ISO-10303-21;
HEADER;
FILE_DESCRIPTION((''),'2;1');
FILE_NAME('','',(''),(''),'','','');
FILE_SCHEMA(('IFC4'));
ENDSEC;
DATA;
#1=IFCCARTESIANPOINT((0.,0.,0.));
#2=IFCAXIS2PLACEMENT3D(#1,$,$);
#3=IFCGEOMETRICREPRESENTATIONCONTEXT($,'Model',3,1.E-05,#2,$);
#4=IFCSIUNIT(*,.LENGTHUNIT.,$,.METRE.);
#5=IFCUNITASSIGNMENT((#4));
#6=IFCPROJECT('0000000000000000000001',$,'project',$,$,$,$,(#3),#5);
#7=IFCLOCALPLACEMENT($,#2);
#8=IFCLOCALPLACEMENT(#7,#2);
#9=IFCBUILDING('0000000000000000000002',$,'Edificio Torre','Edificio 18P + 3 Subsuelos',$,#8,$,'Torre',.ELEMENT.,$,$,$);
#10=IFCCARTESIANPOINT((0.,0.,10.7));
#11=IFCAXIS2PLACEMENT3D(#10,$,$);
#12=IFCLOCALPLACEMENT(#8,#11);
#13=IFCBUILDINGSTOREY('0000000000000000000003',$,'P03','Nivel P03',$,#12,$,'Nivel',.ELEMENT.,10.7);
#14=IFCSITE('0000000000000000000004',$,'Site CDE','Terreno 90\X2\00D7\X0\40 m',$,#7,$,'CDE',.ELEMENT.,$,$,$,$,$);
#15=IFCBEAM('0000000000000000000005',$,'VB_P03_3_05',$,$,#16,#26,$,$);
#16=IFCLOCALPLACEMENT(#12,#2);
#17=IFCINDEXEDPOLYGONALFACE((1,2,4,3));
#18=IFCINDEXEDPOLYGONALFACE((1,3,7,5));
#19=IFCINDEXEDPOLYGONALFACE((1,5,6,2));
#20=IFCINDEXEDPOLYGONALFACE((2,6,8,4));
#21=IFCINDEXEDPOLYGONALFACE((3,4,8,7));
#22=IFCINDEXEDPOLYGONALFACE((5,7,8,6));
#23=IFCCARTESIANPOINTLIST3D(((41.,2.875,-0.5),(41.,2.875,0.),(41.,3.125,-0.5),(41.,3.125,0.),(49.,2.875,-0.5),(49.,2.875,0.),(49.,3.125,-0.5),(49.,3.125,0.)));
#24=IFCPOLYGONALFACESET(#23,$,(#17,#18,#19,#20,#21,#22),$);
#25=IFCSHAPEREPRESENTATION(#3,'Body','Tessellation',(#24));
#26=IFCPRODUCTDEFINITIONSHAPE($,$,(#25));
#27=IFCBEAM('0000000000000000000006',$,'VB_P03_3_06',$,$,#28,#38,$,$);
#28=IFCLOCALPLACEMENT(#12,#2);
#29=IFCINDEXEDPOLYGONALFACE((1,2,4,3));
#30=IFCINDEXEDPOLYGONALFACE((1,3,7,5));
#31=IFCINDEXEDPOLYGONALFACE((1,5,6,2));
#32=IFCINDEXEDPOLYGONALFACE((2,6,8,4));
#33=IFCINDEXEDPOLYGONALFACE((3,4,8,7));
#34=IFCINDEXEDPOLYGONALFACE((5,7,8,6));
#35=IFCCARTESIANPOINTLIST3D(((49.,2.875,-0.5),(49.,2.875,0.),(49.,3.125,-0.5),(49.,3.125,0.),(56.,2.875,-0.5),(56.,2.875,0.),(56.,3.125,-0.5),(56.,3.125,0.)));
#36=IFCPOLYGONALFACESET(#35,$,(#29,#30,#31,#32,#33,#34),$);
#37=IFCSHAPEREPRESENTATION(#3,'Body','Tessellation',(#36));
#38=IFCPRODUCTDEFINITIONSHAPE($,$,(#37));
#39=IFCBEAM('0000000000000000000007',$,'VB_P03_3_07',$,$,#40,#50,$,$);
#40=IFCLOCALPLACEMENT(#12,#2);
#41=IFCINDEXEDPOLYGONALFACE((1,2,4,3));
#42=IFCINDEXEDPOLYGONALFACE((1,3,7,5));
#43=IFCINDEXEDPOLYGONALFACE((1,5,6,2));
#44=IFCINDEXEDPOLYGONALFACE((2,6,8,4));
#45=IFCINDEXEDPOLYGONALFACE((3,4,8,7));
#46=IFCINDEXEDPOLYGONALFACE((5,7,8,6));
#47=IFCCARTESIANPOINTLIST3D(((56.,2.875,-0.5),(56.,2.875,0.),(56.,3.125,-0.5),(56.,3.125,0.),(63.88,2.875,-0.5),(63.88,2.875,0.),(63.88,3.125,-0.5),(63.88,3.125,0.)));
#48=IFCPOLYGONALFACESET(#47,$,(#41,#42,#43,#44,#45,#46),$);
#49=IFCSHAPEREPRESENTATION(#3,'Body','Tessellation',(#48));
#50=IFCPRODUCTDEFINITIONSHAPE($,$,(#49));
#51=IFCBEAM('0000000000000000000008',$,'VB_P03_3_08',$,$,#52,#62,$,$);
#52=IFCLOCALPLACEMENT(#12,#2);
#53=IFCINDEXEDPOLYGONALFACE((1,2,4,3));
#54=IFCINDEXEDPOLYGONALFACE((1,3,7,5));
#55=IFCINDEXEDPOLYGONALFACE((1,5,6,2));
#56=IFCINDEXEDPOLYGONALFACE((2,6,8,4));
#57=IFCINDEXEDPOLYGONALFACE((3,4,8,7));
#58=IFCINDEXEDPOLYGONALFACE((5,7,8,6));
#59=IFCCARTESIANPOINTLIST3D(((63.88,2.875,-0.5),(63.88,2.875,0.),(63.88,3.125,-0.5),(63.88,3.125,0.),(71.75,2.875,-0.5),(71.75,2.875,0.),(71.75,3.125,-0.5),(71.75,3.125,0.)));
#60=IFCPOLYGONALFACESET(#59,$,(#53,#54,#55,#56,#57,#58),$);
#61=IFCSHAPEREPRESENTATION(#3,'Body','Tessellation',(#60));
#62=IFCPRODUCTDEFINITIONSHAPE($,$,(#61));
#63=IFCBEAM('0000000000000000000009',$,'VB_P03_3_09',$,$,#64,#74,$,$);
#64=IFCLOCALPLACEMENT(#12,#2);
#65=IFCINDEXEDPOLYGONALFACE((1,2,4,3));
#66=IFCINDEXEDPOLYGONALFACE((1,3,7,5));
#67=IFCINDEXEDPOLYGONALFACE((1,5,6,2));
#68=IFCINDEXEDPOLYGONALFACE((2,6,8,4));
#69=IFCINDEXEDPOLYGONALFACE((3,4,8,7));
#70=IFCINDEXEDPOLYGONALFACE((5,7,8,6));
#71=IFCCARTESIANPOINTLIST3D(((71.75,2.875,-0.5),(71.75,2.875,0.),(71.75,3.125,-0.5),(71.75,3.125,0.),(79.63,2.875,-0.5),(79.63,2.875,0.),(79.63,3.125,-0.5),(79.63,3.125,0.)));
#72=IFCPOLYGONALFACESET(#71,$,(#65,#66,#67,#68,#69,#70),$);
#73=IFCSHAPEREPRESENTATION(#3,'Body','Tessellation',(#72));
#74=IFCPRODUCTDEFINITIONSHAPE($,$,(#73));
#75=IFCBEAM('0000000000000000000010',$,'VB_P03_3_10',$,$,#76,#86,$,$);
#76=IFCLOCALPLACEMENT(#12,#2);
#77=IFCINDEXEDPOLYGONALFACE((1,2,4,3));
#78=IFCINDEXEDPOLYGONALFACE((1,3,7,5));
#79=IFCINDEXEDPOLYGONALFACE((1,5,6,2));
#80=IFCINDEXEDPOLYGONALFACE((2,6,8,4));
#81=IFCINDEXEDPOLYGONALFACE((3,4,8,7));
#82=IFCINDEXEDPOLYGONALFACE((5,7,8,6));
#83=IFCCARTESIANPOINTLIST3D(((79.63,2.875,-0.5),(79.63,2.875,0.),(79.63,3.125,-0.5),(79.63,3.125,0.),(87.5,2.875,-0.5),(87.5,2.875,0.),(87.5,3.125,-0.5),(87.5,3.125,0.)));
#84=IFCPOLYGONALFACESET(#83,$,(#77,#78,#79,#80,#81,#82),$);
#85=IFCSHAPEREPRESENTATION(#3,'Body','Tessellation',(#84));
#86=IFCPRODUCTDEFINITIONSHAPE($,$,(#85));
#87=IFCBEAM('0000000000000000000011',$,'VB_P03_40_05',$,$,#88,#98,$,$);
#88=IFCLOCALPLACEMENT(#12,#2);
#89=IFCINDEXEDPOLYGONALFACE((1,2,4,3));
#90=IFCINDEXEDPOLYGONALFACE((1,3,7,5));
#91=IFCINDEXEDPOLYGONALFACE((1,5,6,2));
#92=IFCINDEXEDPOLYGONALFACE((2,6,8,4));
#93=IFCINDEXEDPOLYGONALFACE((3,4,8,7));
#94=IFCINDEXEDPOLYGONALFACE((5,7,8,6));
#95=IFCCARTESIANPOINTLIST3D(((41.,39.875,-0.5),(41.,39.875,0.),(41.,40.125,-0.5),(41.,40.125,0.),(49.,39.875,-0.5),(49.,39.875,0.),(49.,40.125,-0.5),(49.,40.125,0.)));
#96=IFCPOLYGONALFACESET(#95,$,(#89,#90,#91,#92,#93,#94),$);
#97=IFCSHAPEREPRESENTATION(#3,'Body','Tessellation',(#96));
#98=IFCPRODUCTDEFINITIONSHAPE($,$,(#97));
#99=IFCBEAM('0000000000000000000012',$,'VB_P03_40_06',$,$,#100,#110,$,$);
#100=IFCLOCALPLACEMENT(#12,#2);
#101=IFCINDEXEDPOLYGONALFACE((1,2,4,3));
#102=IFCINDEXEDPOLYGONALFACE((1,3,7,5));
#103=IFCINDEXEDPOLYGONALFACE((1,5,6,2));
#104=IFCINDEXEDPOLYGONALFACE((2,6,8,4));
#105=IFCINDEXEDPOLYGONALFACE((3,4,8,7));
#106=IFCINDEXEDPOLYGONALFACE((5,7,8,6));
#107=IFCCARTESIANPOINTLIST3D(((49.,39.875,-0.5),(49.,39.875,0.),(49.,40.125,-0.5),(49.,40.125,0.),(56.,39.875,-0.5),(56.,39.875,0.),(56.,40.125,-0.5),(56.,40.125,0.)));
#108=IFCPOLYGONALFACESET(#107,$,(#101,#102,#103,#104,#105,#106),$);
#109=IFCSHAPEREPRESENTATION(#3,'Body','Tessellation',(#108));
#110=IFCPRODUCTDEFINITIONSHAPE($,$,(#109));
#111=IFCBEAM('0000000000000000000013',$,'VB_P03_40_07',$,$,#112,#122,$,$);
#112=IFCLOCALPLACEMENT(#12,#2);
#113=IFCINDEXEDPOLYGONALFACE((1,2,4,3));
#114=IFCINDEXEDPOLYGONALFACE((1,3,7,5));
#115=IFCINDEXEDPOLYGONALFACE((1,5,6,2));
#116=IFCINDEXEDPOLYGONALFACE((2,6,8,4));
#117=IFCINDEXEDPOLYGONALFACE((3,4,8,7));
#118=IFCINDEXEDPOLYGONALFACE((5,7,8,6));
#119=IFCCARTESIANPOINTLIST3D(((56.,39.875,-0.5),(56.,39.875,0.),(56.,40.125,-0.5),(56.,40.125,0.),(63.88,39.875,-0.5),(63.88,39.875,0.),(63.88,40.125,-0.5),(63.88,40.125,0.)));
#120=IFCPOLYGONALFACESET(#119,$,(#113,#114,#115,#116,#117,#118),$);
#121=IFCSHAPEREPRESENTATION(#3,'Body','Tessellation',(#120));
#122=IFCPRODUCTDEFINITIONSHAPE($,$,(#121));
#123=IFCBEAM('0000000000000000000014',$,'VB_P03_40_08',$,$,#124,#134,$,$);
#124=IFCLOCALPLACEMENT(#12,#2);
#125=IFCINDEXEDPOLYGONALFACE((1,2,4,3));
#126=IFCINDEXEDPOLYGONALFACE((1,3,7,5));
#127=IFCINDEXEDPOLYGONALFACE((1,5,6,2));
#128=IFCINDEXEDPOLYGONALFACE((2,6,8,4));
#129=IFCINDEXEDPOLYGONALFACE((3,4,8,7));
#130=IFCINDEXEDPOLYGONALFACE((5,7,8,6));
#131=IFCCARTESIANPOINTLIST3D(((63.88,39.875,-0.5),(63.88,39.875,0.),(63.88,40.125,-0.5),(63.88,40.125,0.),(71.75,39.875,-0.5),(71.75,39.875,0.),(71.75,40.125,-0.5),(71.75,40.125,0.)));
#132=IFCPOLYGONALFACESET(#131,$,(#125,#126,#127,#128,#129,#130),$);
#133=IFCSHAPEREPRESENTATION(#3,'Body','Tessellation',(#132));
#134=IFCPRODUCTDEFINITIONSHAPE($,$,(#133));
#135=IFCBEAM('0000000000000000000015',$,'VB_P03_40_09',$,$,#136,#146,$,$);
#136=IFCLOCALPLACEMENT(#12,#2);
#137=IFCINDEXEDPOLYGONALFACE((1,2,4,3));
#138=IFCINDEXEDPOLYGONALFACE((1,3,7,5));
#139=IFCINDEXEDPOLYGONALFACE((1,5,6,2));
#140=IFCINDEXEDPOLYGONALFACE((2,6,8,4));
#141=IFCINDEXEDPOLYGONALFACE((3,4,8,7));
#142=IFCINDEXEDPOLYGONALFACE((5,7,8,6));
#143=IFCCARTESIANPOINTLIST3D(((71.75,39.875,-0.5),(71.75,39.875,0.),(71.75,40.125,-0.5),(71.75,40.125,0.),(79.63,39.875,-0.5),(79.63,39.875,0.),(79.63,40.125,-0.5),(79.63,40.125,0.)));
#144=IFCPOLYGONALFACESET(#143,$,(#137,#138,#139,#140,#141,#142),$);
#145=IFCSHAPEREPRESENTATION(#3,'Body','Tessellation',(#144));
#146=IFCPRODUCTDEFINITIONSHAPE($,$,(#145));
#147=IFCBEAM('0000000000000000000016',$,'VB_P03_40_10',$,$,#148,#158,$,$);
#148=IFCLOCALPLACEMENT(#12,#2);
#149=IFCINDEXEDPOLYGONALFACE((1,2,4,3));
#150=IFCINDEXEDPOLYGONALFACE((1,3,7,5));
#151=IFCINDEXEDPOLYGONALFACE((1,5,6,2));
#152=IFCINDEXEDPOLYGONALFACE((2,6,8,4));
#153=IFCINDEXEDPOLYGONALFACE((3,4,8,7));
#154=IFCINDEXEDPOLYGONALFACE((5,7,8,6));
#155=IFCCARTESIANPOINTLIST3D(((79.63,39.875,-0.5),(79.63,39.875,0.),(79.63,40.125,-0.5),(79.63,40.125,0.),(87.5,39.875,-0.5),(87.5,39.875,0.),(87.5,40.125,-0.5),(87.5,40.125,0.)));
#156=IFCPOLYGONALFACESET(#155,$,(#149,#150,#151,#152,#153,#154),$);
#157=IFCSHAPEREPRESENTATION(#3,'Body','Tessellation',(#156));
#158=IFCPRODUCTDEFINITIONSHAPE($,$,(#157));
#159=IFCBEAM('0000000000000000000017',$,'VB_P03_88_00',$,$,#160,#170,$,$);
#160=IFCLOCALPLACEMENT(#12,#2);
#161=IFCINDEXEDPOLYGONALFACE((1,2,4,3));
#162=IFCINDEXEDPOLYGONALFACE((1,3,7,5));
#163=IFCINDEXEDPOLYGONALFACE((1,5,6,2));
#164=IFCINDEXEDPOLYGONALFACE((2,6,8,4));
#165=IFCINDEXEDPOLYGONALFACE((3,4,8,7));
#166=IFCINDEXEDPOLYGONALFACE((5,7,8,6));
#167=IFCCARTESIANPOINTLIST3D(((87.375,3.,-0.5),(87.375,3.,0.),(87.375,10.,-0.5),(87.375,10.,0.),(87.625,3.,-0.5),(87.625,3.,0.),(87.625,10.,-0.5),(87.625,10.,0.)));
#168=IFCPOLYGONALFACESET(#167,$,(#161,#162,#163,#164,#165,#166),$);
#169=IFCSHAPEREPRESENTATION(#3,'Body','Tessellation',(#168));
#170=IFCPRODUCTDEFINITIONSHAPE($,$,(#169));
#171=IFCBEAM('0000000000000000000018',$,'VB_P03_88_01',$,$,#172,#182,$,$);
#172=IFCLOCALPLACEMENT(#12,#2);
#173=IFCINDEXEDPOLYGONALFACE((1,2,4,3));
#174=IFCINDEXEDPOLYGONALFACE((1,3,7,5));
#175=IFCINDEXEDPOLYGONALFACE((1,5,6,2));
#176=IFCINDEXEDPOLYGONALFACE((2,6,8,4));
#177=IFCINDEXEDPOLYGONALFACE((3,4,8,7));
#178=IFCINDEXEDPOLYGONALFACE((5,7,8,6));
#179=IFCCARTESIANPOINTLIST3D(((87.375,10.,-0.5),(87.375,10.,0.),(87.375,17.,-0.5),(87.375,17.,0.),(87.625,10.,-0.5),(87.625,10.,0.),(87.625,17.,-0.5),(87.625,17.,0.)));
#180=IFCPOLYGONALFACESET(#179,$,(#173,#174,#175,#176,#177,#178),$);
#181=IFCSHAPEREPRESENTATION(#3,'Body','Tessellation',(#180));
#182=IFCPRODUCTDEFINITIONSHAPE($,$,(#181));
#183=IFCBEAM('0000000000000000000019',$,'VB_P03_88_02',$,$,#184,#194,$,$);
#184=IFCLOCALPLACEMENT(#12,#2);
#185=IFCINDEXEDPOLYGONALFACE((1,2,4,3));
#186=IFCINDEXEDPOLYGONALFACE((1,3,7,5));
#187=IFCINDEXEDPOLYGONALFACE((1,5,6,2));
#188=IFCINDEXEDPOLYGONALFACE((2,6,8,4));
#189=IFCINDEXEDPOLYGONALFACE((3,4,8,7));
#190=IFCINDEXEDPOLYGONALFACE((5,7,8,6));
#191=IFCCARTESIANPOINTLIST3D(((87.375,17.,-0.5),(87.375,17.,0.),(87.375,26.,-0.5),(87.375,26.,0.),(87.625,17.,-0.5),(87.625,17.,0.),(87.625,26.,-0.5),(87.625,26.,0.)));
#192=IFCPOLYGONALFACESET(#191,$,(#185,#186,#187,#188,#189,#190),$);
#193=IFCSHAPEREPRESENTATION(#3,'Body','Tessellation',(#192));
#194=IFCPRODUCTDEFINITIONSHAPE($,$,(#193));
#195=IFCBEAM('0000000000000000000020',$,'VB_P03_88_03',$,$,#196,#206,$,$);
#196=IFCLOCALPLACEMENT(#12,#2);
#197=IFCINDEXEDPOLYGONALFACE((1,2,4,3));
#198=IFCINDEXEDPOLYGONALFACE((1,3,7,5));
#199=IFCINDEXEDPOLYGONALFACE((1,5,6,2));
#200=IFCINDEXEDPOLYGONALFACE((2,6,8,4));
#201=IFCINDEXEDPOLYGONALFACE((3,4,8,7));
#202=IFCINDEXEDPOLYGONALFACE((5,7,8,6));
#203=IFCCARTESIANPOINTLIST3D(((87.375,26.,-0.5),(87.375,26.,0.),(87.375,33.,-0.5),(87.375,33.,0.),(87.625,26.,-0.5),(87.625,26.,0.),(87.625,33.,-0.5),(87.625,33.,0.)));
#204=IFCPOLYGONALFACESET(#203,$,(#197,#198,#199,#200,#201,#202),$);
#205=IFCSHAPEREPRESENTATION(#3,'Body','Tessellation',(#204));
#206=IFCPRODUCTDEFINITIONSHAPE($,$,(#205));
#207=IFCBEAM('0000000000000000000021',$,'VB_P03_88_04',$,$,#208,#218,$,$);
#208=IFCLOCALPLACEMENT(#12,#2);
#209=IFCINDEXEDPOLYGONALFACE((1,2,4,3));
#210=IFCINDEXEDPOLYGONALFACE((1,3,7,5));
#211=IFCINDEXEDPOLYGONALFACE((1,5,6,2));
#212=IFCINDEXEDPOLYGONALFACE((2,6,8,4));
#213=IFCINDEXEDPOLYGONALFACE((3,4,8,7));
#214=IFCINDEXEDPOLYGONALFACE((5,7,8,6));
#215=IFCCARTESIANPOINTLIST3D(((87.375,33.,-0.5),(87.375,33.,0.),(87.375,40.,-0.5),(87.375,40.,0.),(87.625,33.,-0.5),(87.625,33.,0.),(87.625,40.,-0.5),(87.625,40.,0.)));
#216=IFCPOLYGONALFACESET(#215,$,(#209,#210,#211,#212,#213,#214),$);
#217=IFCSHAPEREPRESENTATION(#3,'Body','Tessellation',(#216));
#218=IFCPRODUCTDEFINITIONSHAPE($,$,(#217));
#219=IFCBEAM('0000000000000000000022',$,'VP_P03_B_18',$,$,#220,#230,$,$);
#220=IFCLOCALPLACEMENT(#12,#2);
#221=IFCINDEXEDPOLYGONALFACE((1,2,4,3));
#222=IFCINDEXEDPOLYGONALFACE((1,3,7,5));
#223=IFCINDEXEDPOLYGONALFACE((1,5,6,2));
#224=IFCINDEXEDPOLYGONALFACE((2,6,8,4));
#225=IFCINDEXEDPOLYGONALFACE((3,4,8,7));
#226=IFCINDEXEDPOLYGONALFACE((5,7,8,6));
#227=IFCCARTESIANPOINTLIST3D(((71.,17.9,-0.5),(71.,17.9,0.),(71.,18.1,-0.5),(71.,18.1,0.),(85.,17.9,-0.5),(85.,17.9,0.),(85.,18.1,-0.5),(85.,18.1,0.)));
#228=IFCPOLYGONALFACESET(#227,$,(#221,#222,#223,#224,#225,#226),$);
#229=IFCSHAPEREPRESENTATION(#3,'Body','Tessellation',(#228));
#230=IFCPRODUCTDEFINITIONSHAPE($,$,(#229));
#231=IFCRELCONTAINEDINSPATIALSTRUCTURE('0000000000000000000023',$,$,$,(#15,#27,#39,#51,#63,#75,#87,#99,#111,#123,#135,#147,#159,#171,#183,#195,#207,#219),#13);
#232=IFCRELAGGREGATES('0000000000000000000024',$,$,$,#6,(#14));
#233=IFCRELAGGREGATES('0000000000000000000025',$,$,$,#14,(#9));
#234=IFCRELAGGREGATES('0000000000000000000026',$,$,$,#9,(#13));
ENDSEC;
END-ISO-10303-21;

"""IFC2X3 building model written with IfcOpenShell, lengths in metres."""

from ifc_helpers import new_model, si_unit, frame, origin, origin_2d, place, context, project, spatial, rectangle, extrude, element, save


model = new_model("IFC2X3")

# Units and contexts
model_context = context("Model", 3, precision=1e-05, world=origin())
ifc_project = project(units=[si_unit("LENGTHUNIT", "METRE")], contexts=[model_context])

# Site, building, storey
site_placement = place(None, origin())
site = spatial("IfcSite", under=ifc_project, at=site_placement, Name="Site CDE", Description="Terreno 90×40 m", LongName="CDE", CompositionType="ELEMENT")
building_placement = place(site_placement, origin())
building = spatial("IfcBuilding", under=site, at=building_placement, Name="Edificio Torre", Description="Edificio 18P + 3 Subsuelos", LongName="Torre", CompositionType="ELEMENT")
storey_placement = place(building_placement, frame((0.0, 0.0, 10.7)))
storey = spatial("IfcBuildingStorey", under=building, at=storey_placement, Name="P03", Description="Nivel P03", LongName="Nivel", CompositionType="ELEMENT", Elevation=10.7)

# Beams
beam_1_placement = place(storey_placement, frame((45.0, 3.0, -0.5)))
element("IfcBeam", 1, at=beam_1_placement, inside=storey, Name="VB_P03_3_05", context=model_context, shape_type="SweptSolid", body=[
    extrude(rectangle(XDim=8.0, YDim=0.25, at=origin_2d()), origin(), (0.0, 0.0, 1.0), 0.5),
])
beam_2_placement = place(storey_placement, frame((52.5, 3.0, -0.5)))
element("IfcBeam", 2, at=beam_2_placement, inside=storey, Name="VB_P03_3_06", context=model_context, shape_type="SweptSolid", body=[
    extrude(rectangle(XDim=7.0, YDim=0.25, at=origin_2d()), origin(), (0.0, 0.0, 1.0), 0.5),
])
beam_3_placement = place(storey_placement, frame((59.94, 3.0, -0.5)))
element("IfcBeam", 3, at=beam_3_placement, inside=storey, Name="VB_P03_3_07", context=model_context, shape_type="SweptSolid", body=[
    extrude(rectangle(XDim=7.88, YDim=0.25, at=origin_2d()), origin(), (0.0, 0.0, 1.0), 0.5),
])
beam_4_placement = place(storey_placement, frame((67.815, 3.0, -0.5)))
element("IfcBeam", 4, at=beam_4_placement, inside=storey, Name="VB_P03_3_08", context=model_context, shape_type="SweptSolid", body=[
    extrude(rectangle(XDim=7.87, YDim=0.25, at=origin_2d()), origin(), (0.0, 0.0, 1.0), 0.5),
])
beam_5_placement = place(storey_placement, frame((75.69, 3.0, -0.5)))
element("IfcBeam", 5, at=beam_5_placement, inside=storey, Name="VB_P03_3_09", context=model_context, shape_type="SweptSolid", body=[
    extrude(rectangle(XDim=7.88, YDim=0.25, at=origin_2d()), origin(), (0.0, 0.0, 1.0), 0.5),
])
beam_6_placement = place(storey_placement, frame((83.565, 3.0, -0.5)))
element("IfcBeam", 6, at=beam_6_placement, inside=storey, Name="VB_P03_3_10", context=model_context, shape_type="SweptSolid", body=[
    extrude(rectangle(XDim=7.87, YDim=0.25, at=origin_2d()), origin(), (0.0, 0.0, 1.0), 0.5),
])
beam_7_placement = place(storey_placement, frame((45.0, 40.0, -0.5)))
element("IfcBeam", 7, at=beam_7_placement, inside=storey, Name="VB_P03_40_05", context=model_context, shape_type="SweptSolid", body=[
    extrude(rectangle(XDim=8.0, YDim=0.25, at=origin_2d()), origin(), (0.0, 0.0, 1.0), 0.5),
])
beam_8_placement = place(storey_placement, frame((52.5, 40.0, -0.5)))
element("IfcBeam", 8, at=beam_8_placement, inside=storey, Name="VB_P03_40_06", context=model_context, shape_type="SweptSolid", body=[
    extrude(rectangle(XDim=7.0, YDim=0.25, at=origin_2d()), origin(), (0.0, 0.0, 1.0), 0.5),
])
beam_9_placement = place(storey_placement, frame((59.94, 40.0, -0.5)))
element("IfcBeam", 9, at=beam_9_placement, inside=storey, Name="VB_P03_40_07", context=model_context, shape_type="SweptSolid", body=[
    extrude(rectangle(XDim=7.88, YDim=0.25, at=origin_2d()), origin(), (0.0, 0.0, 1.0), 0.5),
])
beam_10_placement = place(storey_placement, frame((67.815, 40.0, -0.5)))
element("IfcBeam", 10, at=beam_10_placement, inside=storey, Name="VB_P03_40_08", context=model_context, shape_type="SweptSolid", body=[
    extrude(rectangle(XDim=7.87, YDim=0.25, at=origin_2d()), origin(), (0.0, 0.0, 1.0), 0.5),
])
beam_11_placement = place(storey_placement, frame((75.69, 40.0, -0.5)))
element("IfcBeam", 11, at=beam_11_placement, inside=storey, Name="VB_P03_40_09", context=model_context, shape_type="SweptSolid", body=[
    extrude(rectangle(XDim=7.88, YDim=0.25, at=origin_2d()), origin(), (0.0, 0.0, 1.0), 0.5),
])
beam_12_placement = place(storey_placement, frame((83.565, 40.0, -0.5)))
element("IfcBeam", 12, at=beam_12_placement, inside=storey, Name="VB_P03_40_10", context=model_context, shape_type="SweptSolid", body=[
    extrude(rectangle(XDim=7.87, YDim=0.25, at=origin_2d()), origin(), (0.0, 0.0, 1.0), 0.5),
])
for number, where, name in (
    (13, (87.5, 6.5, -0.5), "VB_P03_88_00"),
    (14, (87.5, 13.5, -0.5), "VB_P03_88_01"),
):
    element("IfcBeam", number, at=place(storey_placement, frame(where)), inside=storey, Name=name, context=model_context, shape_type="SweptSolid", body=[
        extrude(rectangle(XDim=0.25, YDim=7.0, at=origin_2d()), origin(), (0.0, 0.0, 1.0), 0.5),
    ])
beam_13_placement = place(storey_placement, frame((87.5, 21.5, -0.5)))
element("IfcBeam", 15, at=beam_13_placement, inside=storey, Name="VB_P03_88_02", context=model_context, shape_type="SweptSolid", body=[
    extrude(rectangle(XDim=0.25, YDim=9.0, at=origin_2d()), origin(), (0.0, 0.0, 1.0), 0.5),
])
for number, where, name in (
    (16, (87.5, 29.5, -0.5), "VB_P03_88_03"),
    (17, (87.5, 36.5, -0.5), "VB_P03_88_04"),
):
    element("IfcBeam", number, at=place(storey_placement, frame(where)), inside=storey, Name=name, context=model_context, shape_type="SweptSolid", body=[
        extrude(rectangle(XDim=0.25, YDim=7.0, at=origin_2d()), origin(), (0.0, 0.0, 1.0), 0.5),
    ])
for number, where, name in (
    (18, (78.0, 18.0, -0.5), "VP_P03_B_18"),
):
    element("IfcBeam", number, at=place(storey_placement, frame(where)), inside=storey, Name=name, context=model_context, shape_type="SweptSolid", body=[
        extrude(rectangle(XDim=14.0, YDim=0.2, at=origin_2d()), origin(), (0.0, 0.0, 1.0), 0.5),
    ])

save(model, "model.ifc")
